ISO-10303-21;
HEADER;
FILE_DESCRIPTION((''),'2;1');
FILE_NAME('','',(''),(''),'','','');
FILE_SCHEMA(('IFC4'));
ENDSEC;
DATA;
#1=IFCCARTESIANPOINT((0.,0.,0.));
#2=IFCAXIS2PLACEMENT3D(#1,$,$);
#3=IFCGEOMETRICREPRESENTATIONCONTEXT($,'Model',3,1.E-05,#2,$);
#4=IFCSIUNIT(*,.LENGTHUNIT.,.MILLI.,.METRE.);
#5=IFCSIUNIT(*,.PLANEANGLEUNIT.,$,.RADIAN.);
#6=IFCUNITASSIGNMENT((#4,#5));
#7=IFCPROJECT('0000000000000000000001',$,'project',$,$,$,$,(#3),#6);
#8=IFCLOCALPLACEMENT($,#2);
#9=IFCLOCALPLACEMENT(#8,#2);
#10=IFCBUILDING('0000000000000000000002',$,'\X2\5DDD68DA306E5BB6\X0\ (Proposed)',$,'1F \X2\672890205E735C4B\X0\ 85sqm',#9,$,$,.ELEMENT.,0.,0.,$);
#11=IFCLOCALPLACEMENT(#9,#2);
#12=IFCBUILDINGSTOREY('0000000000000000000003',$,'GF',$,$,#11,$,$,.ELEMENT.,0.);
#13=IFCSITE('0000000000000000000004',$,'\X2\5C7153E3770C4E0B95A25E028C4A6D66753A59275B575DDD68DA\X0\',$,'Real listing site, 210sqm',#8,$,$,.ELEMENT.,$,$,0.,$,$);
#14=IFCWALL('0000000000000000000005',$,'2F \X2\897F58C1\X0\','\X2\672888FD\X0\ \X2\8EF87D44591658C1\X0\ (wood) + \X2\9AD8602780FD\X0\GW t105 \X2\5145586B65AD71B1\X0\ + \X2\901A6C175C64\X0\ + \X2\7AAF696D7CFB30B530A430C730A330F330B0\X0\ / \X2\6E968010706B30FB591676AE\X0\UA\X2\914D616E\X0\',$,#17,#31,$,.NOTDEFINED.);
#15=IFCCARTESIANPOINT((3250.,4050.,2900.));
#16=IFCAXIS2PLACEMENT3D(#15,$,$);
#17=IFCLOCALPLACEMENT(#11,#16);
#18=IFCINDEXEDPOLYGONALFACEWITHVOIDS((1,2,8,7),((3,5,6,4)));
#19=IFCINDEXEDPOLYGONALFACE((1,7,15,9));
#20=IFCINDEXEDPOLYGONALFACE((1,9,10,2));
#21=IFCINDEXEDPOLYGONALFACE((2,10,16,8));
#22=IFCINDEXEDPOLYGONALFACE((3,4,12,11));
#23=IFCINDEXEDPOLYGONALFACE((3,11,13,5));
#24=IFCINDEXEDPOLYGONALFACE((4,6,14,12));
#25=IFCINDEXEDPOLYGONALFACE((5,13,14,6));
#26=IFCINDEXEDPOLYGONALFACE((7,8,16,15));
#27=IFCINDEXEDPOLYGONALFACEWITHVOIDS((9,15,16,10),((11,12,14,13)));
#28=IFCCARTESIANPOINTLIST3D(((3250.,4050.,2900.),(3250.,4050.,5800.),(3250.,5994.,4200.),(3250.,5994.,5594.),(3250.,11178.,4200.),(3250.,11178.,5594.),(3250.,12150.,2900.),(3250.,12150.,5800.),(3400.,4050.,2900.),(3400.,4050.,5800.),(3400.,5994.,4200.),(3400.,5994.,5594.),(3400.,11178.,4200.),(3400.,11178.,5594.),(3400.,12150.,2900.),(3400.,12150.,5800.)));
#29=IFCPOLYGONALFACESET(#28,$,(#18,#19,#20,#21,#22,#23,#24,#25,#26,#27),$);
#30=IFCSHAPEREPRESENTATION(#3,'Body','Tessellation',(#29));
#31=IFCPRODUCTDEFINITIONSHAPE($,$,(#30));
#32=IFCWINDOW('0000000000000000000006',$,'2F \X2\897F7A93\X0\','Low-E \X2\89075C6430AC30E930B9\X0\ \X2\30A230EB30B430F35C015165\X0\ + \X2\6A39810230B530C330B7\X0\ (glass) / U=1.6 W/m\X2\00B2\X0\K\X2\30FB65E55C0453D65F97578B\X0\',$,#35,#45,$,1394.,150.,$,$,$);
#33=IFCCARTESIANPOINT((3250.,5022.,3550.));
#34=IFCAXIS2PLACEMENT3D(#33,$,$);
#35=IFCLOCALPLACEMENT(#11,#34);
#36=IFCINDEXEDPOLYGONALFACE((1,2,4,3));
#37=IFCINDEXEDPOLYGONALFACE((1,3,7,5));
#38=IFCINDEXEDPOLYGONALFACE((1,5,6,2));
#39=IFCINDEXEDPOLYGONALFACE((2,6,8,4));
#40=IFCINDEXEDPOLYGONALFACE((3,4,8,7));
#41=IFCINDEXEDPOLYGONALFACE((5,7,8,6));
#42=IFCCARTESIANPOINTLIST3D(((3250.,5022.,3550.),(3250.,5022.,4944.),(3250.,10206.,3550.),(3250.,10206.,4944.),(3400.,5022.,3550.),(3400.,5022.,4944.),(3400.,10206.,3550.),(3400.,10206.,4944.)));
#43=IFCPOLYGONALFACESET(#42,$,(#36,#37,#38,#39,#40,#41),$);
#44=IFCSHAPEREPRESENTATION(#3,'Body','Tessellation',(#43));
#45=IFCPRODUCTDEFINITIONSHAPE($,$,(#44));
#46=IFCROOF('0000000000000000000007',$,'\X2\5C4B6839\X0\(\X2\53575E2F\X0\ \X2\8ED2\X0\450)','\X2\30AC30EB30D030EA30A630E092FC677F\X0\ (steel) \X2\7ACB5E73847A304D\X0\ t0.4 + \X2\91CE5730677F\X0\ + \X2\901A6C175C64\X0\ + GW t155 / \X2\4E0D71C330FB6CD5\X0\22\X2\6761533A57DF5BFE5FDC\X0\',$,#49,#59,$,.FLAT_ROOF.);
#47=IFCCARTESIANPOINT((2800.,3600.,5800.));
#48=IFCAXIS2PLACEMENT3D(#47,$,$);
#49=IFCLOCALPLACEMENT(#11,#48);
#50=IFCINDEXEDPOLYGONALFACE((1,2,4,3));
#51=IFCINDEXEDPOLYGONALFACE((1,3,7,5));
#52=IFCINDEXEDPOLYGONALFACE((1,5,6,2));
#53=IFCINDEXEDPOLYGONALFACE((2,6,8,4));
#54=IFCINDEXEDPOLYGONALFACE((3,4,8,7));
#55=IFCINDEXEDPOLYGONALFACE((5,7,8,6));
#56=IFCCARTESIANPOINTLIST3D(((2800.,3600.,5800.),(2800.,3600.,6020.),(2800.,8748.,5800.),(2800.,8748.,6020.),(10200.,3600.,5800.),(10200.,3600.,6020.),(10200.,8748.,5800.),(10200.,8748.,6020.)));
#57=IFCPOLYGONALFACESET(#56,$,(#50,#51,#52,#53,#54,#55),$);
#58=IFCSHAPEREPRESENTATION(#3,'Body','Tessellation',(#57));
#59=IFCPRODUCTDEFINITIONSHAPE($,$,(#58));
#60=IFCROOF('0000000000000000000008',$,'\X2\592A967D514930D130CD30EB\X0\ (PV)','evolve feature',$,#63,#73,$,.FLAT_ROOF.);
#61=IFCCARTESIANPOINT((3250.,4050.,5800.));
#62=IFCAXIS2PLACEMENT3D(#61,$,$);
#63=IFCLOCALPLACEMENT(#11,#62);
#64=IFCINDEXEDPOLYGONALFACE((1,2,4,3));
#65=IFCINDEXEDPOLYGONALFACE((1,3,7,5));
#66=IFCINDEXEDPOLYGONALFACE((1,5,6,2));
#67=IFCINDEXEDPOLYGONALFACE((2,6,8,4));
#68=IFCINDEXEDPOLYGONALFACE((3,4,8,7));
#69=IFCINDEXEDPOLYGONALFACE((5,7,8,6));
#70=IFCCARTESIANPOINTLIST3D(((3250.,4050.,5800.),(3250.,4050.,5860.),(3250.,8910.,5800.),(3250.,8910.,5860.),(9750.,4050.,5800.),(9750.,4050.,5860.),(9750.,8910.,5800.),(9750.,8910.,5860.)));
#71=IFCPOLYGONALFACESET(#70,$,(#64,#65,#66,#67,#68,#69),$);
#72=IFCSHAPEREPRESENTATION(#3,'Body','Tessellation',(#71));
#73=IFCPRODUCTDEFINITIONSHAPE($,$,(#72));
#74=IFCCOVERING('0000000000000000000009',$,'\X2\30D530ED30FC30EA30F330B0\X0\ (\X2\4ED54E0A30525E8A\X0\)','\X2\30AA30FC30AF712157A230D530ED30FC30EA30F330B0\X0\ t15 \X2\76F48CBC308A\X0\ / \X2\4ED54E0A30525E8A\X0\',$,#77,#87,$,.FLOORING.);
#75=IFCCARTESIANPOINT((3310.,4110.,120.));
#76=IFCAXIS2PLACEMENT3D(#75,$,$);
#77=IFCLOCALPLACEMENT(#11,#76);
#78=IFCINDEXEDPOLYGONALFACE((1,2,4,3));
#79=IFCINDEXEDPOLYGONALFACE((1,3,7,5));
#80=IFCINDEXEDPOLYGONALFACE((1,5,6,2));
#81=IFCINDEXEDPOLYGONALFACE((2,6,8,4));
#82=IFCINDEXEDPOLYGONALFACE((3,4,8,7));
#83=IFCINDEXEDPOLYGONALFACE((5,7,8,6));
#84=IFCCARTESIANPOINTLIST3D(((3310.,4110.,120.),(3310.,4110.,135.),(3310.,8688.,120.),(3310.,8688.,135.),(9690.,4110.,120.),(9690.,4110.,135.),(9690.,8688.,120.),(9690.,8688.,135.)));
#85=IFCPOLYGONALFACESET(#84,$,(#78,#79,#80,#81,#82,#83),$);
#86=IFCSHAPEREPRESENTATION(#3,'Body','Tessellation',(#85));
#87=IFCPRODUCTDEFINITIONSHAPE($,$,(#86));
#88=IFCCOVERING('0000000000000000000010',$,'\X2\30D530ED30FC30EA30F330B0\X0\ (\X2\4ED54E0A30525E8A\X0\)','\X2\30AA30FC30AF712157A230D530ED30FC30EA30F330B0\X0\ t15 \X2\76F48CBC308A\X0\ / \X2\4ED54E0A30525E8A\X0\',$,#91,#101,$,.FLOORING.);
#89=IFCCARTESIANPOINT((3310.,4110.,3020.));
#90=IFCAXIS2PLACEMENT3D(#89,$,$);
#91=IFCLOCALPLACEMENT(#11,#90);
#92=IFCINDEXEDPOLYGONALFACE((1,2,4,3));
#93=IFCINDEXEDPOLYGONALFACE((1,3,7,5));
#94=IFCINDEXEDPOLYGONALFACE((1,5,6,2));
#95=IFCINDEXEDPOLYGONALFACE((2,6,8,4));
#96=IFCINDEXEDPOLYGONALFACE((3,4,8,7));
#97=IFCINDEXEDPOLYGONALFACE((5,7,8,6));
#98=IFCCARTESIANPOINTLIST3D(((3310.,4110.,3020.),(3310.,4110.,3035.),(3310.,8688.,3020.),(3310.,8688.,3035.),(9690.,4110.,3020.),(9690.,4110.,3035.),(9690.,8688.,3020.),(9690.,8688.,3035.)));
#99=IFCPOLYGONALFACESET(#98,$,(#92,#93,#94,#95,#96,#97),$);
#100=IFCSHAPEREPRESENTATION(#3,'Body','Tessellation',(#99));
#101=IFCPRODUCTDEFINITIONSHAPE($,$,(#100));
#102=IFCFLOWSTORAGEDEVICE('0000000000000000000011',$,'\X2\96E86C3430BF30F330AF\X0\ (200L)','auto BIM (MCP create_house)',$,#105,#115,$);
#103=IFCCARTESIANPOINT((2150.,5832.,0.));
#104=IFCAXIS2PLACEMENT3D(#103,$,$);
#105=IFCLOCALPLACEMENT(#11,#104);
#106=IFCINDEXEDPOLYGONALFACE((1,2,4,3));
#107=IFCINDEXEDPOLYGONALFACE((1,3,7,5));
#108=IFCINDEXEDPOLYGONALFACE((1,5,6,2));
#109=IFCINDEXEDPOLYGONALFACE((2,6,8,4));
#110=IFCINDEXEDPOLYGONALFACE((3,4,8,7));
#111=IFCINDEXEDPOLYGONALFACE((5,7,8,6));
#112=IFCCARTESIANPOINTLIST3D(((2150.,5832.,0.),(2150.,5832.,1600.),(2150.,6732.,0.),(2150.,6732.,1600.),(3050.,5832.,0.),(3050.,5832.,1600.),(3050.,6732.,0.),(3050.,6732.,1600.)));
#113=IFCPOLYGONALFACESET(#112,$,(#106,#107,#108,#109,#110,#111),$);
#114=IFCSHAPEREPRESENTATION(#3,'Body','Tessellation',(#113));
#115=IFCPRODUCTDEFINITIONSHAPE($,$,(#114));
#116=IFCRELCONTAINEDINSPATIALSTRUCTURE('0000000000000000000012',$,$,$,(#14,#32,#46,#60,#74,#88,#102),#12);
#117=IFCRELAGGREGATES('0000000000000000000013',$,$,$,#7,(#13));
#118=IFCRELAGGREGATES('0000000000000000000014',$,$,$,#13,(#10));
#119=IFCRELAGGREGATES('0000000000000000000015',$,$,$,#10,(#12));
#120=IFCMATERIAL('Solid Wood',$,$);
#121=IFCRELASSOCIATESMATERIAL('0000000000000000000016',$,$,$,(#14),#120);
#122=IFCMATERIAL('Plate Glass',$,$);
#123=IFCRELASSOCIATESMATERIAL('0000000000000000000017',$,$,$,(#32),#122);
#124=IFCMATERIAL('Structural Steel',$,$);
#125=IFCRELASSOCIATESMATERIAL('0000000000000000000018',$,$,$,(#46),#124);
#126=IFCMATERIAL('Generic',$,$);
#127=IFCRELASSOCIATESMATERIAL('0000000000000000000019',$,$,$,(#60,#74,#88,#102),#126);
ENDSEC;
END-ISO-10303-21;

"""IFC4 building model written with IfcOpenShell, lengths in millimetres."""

from ifc_helpers import new_model, si_unit, frame, frame_2d, origin, place, context, project, spatial, rectangle, extrude, material, element, fill, save


model = new_model("IFC4")

# Units and contexts
model_context = context("Model", 3, precision=1e-05, world=origin())
ifc_project = project(units=[si_unit("LENGTHUNIT", "METRE", prefix="MILLI"), si_unit("PLANEANGLEUNIT", "RADIAN")], contexts=[model_context])

# Site, building, storey
site_placement = place(None, origin())
site = spatial("IfcSite", under=ifc_project, at=site_placement, Name="山口県下関市豊浦町大字川棚", ObjectType="Real listing site, 210sqm", CompositionType="ELEMENT", RefElevation=0.0)
building_placement = place(site_placement, origin())
building = spatial("IfcBuilding", under=site, at=building_placement, Name="川棚の家 (Proposed)", ObjectType="1F 木造平屋 85sqm", CompositionType="ELEMENT", ElevationOfRefHeight=0.0, ElevationOfTerrain=0.0)
storey_placement = place(building_placement, origin())
storey = spatial("IfcBuildingStorey", under=building, at=storey_placement, Name="GF", CompositionType="ELEMENT", Elevation=0.0)

# Shared definitions
ifc_material_1 = material(Name="Solid Wood")
ifc_material_2 = material(Name="Generic")

# Shared definitions
ifc_material_3 = material(Name="Plate Glass")

# Wall, opening, window
wall_1_placement = place(storey_placement, frame((3250.0, 4050.0, 2900.0)))
wall_1 = element("IfcWall", 1, at=wall_1_placement, inside=storey, material=ifc_material_1, Name="2F 西壁", Description="木製 軸組外壁 (wood) + 高性能GW t105 充填断熱 + 通気層 + 窯業系サイディング / 準耐火・外皮UA配慮", PredefinedType="NOTDEFINED", context=model_context, shape_type="SweptSolid", body=[
    extrude(rectangle(XDim=150.0, YDim=8100.0, at=frame_2d((75.0, 4050.0))), frame((3250.0, 4050.0, 2900.0)), (0.0, 0.0, 1.0), 2900.0),
])
opening_1_placement = place(storey_placement, frame((3250.0, 5022.0, 3550.0)))
opening_1 = element("IfcOpeningElement", 2, at=opening_1_placement, cuts=wall_1, PredefinedType="NOTDEFINED", context=model_context, shape_type="SweptSolid", body=[
    extrude(rectangle(XDim=150.0, YDim=5184.0, at=frame_2d((75.0, 2592.0))), frame((3250.0, 5022.0, 3550.0)), (0.0, 0.0, 1.0), 1394.0),
])
window_1_placement = place(storey_placement, frame((3250.0, 5022.0, 3550.0)))
window_1 = element("IfcWindow", 3, at=window_1_placement, inside=storey, material=ifc_material_3, Name="2F 西窓", Description="Low-E 複層ガラス アルゴン封入 + 樹脂サッシ (glass) / U=1.6 W/m²K・日射取得型", OverallHeight=1394.0, OverallWidth=150.0, context=model_context, shape_type="SweptSolid", body=[
    extrude(rectangle(XDim=150.0, YDim=5184.0, at=frame_2d((75.0, 2592.0))), frame((3250.0, 5022.0, 3550.0)), (0.0, 0.0, 1.0), 1394.0),
])
fill(opening_1, window_1)

# Roofs
ifc_material_4 = material(Name="Structural Steel")
for number, where, name in (
    (4, (2800.0, 3600.0, 5800.0), "屋根(南帯 軒450)"),
):
    element("IfcRoof", number, at=place(storey_placement, frame(where)), inside=storey, material=ifc_material_4, Name=name, Description="ガルバリウム鋼板 (steel) 立平葺き t0.4 + 野地板 + 通気層 + GW t155 / 不燃・法22条区域対応", PredefinedType="FLAT_ROOF", context=model_context, shape_type="SweptSolid", body=[
        extrude(rectangle(XDim=7400.0, YDim=5148.0, at=frame_2d((3700.0, 2574.0))), frame((2800.0, 3600.0, 5800.0)), (0.0, 0.0, 1.0), 220.0),
    ])
roof_placement = place(storey_placement, frame((3250.0, 4050.0, 5800.0)))
element("IfcRoof", 5, at=roof_placement, inside=storey, material=ifc_material_2, Name="太陽光パネル (PV)", Description="evolve feature", PredefinedType="FLAT_ROOF", context=model_context, shape_type="SweptSolid", body=[
    extrude(rectangle(XDim=6500.0, YDim=4860.0, at=frame_2d((3250.0, 2430.0))), frame((3250.0, 4050.0, 5800.0)), (0.0, 0.0, 1.0), 60.0),
])

# Coverings
covering_1_placement = place(storey_placement, frame((3310.0, 4110.0, 120.0)))
element("IfcCovering", 6, at=covering_1_placement, inside=storey, material=ifc_material_2, Name="フローリング (仕上げ床)", Description="オーク無垢フローリング t15 直貼り / 仕上げ床", PredefinedType="FLOORING", context=model_context, shape_type="SweptSolid", body=[
    extrude(rectangle(XDim=6380.0, YDim=4578.0, at=frame_2d((3190.0, 2289.0))), frame((3310.0, 4110.0, 120.0)), (0.0, 0.0, 1.0), 15.0),
])
covering_2_placement = place(storey_placement, frame((3310.0, 4110.0, 3020.0)))
element("IfcCovering", 7, at=covering_2_placement, inside=storey, material=ifc_material_2, Name="フローリング (仕上げ床)", Description="オーク無垢フローリング t15 直貼り / 仕上げ床", PredefinedType="FLOORING", context=model_context, shape_type="SweptSolid", body=[
    extrude(rectangle(XDim=6380.0, YDim=4578.0, at=frame_2d((3190.0, 2289.0))), frame((3310.0, 4110.0, 3020.0)), (0.0, 0.0, 1.0), 15.0),
])

# Flow storage device
flow_storage_device_placement = place(storey_placement, frame((2150.0, 5832.0, 0.0)))
element("IfcFlowStorageDevice", 8, at=flow_storage_device_placement, inside=storey, material=ifc_material_2, Name="雨水タンク (200L)", Description="auto BIM (MCP create_house)", context=model_context, shape_type="SweptSolid", body=[
    extrude(rectangle(XDim=900.0, YDim=900.0, at=frame_2d((450.0, 450.0))), frame((2150.0, 5832.0, 0.0)), (0.0, 0.0, 1.0), 1600.0),
])

save(model, "model.ifc")
